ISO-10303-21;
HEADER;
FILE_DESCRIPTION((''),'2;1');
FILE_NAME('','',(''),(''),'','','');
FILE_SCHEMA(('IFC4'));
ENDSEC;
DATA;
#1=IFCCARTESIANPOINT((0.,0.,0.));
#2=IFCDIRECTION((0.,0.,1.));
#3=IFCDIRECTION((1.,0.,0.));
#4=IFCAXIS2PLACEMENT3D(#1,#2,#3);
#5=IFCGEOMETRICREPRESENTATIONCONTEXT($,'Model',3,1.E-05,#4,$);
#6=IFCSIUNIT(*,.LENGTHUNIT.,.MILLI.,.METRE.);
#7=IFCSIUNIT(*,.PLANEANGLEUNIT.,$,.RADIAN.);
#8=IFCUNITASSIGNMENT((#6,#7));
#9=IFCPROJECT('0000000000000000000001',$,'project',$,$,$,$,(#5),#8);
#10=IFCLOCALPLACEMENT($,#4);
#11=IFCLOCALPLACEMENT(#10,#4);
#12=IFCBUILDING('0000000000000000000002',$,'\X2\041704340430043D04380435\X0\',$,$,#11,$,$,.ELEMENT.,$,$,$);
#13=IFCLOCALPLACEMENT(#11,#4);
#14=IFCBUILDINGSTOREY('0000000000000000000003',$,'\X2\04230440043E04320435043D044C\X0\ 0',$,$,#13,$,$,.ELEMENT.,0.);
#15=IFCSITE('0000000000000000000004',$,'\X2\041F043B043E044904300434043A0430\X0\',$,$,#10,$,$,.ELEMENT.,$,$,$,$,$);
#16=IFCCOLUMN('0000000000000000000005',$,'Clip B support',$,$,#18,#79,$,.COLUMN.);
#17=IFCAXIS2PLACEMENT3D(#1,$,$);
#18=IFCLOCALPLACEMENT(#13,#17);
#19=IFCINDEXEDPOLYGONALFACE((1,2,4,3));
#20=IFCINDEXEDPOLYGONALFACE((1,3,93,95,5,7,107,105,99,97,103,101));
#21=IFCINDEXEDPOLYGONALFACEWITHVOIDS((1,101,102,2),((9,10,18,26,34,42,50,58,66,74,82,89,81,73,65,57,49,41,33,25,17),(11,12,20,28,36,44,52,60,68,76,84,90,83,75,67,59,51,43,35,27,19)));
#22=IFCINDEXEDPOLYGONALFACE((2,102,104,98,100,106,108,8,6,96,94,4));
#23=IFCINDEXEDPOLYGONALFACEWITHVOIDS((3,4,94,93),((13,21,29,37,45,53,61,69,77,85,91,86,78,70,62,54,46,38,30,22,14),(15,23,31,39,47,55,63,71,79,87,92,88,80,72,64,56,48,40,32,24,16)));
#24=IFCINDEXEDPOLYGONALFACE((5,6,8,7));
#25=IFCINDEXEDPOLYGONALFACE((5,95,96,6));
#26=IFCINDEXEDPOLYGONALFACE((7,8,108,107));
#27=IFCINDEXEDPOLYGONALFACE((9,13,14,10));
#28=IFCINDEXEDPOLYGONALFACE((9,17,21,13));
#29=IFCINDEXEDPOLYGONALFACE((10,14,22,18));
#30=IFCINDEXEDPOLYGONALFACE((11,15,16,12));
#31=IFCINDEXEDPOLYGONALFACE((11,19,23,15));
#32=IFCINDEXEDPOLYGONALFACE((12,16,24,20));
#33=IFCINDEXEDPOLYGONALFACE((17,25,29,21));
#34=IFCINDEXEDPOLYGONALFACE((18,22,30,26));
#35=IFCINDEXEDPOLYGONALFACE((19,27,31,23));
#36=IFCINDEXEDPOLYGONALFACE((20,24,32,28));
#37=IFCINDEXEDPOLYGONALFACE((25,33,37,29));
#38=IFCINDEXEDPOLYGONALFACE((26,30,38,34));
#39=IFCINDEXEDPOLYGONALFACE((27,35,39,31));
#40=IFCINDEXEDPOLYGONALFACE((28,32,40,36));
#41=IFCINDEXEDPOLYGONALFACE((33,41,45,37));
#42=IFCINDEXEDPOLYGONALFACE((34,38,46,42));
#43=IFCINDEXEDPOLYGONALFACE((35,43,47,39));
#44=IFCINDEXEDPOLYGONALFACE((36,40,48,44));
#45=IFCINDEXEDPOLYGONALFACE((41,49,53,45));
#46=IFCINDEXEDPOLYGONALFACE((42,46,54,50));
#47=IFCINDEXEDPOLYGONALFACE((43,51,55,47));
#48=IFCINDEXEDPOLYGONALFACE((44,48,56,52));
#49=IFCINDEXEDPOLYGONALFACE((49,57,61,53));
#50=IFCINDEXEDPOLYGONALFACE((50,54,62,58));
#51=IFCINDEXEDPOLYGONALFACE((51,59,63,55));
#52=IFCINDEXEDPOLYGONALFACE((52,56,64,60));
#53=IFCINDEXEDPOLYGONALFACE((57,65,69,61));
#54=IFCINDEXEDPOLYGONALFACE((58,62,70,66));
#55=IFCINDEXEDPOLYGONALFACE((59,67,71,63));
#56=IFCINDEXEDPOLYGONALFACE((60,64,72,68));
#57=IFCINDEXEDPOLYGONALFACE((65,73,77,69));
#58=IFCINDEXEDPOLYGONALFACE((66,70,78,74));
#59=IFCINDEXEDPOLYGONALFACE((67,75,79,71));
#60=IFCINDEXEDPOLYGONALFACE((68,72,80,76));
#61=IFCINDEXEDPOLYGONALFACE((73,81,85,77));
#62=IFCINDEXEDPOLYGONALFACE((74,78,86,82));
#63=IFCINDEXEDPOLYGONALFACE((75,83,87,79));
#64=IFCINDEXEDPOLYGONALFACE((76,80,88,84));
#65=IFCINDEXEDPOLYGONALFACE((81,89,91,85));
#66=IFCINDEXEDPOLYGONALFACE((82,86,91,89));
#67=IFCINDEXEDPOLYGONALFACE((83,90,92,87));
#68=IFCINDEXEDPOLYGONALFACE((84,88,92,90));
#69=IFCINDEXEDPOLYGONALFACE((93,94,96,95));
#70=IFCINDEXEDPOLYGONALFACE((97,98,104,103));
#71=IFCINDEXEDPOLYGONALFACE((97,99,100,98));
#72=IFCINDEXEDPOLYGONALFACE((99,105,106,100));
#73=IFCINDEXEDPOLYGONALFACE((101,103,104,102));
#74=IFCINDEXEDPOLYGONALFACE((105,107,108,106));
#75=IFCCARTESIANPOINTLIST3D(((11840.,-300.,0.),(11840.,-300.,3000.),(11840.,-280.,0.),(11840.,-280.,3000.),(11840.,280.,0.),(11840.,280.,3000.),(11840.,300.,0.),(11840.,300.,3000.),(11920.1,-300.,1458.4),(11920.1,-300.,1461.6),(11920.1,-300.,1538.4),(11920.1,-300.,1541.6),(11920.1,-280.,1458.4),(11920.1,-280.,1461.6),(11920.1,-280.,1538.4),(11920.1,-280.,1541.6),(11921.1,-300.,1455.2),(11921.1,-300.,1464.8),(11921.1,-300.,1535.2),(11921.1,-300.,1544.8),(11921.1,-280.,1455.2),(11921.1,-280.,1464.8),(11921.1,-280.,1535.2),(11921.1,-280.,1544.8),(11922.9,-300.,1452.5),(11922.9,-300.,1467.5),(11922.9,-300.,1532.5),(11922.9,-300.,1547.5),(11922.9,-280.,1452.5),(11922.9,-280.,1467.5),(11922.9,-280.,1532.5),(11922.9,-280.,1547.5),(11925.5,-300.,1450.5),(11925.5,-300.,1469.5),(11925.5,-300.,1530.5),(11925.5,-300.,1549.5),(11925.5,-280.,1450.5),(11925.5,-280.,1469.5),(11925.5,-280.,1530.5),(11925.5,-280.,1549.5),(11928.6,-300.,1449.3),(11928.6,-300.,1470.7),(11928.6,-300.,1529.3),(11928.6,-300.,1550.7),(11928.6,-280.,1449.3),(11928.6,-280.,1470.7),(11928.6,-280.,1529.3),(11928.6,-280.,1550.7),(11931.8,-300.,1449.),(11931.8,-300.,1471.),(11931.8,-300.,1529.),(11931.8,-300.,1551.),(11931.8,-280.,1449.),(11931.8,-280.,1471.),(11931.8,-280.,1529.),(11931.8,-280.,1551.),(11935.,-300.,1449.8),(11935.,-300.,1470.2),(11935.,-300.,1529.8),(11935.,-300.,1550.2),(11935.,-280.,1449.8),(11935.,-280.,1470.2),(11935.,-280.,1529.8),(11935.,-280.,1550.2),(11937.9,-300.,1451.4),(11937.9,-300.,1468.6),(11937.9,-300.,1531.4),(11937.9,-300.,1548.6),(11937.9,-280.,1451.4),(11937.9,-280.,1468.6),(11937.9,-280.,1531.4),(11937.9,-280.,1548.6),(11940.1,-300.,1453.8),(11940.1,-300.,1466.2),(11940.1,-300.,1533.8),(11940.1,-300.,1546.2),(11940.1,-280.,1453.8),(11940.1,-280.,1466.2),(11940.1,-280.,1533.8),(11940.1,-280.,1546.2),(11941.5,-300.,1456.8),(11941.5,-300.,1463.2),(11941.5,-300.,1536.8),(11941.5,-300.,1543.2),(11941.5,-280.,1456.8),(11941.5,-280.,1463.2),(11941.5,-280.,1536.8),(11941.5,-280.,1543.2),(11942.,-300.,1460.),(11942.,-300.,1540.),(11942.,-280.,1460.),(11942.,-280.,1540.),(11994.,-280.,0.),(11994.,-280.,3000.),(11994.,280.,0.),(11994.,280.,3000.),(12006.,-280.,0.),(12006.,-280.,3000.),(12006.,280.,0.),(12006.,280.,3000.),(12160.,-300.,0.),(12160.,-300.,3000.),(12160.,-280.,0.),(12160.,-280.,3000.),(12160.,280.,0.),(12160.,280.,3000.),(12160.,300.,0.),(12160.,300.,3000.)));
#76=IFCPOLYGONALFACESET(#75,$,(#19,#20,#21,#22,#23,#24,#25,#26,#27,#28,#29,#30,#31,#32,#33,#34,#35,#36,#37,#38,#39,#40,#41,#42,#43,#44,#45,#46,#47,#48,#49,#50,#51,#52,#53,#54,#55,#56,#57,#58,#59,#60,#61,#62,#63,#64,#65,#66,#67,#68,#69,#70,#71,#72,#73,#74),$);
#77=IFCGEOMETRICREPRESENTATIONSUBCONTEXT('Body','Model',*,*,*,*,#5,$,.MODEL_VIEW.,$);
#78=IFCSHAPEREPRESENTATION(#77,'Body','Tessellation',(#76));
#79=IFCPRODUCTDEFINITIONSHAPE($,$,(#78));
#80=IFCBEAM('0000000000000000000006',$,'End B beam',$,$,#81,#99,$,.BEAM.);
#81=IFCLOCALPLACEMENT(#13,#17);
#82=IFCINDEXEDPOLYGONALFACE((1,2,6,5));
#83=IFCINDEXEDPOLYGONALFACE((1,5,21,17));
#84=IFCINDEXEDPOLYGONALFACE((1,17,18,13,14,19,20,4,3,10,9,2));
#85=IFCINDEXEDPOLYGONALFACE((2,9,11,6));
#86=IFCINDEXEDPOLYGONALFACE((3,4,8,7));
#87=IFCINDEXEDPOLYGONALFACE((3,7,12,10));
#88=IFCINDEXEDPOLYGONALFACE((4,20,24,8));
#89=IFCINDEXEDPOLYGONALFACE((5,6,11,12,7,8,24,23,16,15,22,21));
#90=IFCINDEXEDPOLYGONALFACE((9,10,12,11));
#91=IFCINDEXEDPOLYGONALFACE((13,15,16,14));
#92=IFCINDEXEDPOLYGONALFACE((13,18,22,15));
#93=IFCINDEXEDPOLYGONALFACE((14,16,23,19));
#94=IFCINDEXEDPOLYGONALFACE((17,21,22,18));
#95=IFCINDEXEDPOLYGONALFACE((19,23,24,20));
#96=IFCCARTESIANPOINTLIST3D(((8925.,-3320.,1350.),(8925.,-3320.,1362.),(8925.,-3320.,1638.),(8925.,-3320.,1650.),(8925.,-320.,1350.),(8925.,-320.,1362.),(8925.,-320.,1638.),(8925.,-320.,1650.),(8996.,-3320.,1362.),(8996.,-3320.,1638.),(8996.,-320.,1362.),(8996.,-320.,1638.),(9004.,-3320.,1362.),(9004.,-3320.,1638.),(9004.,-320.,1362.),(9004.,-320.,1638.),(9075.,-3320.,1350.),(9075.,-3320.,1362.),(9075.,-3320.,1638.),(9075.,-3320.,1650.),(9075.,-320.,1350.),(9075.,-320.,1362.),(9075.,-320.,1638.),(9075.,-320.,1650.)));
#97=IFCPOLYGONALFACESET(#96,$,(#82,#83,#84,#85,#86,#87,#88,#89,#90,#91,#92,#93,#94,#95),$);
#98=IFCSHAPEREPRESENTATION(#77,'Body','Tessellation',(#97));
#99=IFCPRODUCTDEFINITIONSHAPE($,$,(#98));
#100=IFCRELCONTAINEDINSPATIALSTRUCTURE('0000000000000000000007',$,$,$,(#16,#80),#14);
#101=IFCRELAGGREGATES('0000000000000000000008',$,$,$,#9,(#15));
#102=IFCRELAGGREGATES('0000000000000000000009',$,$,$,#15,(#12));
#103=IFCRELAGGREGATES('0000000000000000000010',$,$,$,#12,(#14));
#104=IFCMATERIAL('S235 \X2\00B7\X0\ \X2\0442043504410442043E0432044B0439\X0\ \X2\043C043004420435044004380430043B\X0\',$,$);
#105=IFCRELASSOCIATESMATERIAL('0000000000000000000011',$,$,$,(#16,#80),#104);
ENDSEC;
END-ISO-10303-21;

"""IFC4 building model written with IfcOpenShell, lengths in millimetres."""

from ifc_helpers import new_model, si_unit, frame, origin_with_axes, place, context, subcontext, project, spatial, circle, i_section, extrude, material, element, save


model = new_model("IFC4")

# Units and contexts
model_context = context("Model", 3, precision=1e-05, world=origin_with_axes())
body_context = subcontext(model_context, "Body", "Model", "MODEL_VIEW")
ifc_project = project(units=[si_unit("LENGTHUNIT", "METRE", prefix="MILLI"), si_unit("PLANEANGLEUNIT", "RADIAN")], contexts=[model_context])

# Site, building, storey
site_placement = place(None, origin_with_axes())
site = spatial("IfcSite", under=ifc_project, at=site_placement, Name="Площадка", CompositionType="ELEMENT")
building_placement = place(site_placement, origin_with_axes())
building = spatial("IfcBuilding", under=site, at=building_placement, Name="Здание", CompositionType="ELEMENT")
storey_placement = place(building_placement, origin_with_axes())
storey = spatial("IfcBuildingStorey", under=building, at=storey_placement, Name="Уровень 0", CompositionType="ELEMENT", Elevation=0.0)

# Column, openings
ifc_material = material(Name="S235 · тестовый материал")
column_1_placement = place(storey_placement, frame((12000.0, 0.0, 0.0), z_axis=(0.0, 0.0, 1.0), x_axis=(1.0, 0.0, 0.0)))
column_1 = element("IfcColumn", 1, at=column_1_placement, inside=storey, material=ifc_material, Name="Clip B support", PredefinedType="COLUMN", context=body_context, shape_type="SweptSolid", body=[
    extrude(i_section(OverallWidth=320.0, OverallDepth=600.0, WebThickness=12.0, FlangeThickness=20.0), origin_with_axes(), (0.0, 0.0, 1.0), 3000.0),
])
opening_1_placement = place(column_1_placement, frame((-69.0, -321.0, 1540.0), z_axis=(0.0, 1.0, 0.0), x_axis=(1.0, 0.0, 0.0)))
element("IfcOpeningElement", 2, at=opening_1_placement, cuts=column_1, PredefinedType="OPENING", context=body_context, shape_type="SweptSolid", body=[
    extrude(circle(Radius=11.0), origin_with_axes(), (0.0, 0.0, 1.0), 42.0),
])
opening_2_placement = place(column_1_placement, frame((-69.0, -321.0, 1460.0), z_axis=(0.0, 1.0, 0.0), x_axis=(1.0, 0.0, 0.0)))
element("IfcOpeningElement", 3, at=opening_2_placement, cuts=column_1, PredefinedType="OPENING", context=body_context, shape_type="SweptSolid", body=[
    extrude(circle(Radius=11.0), origin_with_axes(), (0.0, 0.0, 1.0), 42.0),
])

# Beam
beam_1_placement = place(storey_placement, frame((9000.0, -3320.0, 1500.0), z_axis=(0.0, 1.0, 0.0), x_axis=(-1.0, 0.0, 0.0)))
element("IfcBeam", 4, at=beam_1_placement, inside=storey, material=ifc_material, Name="End B beam", PredefinedType="BEAM", context=body_context, shape_type="SweptSolid", body=[
    extrude(i_section(OverallWidth=150.0, OverallDepth=300.0, WebThickness=8.0, FlangeThickness=12.0), origin_with_axes(), (0.0, 0.0, 1.0), 3000.0),
])

save(model, "model.ifc")
